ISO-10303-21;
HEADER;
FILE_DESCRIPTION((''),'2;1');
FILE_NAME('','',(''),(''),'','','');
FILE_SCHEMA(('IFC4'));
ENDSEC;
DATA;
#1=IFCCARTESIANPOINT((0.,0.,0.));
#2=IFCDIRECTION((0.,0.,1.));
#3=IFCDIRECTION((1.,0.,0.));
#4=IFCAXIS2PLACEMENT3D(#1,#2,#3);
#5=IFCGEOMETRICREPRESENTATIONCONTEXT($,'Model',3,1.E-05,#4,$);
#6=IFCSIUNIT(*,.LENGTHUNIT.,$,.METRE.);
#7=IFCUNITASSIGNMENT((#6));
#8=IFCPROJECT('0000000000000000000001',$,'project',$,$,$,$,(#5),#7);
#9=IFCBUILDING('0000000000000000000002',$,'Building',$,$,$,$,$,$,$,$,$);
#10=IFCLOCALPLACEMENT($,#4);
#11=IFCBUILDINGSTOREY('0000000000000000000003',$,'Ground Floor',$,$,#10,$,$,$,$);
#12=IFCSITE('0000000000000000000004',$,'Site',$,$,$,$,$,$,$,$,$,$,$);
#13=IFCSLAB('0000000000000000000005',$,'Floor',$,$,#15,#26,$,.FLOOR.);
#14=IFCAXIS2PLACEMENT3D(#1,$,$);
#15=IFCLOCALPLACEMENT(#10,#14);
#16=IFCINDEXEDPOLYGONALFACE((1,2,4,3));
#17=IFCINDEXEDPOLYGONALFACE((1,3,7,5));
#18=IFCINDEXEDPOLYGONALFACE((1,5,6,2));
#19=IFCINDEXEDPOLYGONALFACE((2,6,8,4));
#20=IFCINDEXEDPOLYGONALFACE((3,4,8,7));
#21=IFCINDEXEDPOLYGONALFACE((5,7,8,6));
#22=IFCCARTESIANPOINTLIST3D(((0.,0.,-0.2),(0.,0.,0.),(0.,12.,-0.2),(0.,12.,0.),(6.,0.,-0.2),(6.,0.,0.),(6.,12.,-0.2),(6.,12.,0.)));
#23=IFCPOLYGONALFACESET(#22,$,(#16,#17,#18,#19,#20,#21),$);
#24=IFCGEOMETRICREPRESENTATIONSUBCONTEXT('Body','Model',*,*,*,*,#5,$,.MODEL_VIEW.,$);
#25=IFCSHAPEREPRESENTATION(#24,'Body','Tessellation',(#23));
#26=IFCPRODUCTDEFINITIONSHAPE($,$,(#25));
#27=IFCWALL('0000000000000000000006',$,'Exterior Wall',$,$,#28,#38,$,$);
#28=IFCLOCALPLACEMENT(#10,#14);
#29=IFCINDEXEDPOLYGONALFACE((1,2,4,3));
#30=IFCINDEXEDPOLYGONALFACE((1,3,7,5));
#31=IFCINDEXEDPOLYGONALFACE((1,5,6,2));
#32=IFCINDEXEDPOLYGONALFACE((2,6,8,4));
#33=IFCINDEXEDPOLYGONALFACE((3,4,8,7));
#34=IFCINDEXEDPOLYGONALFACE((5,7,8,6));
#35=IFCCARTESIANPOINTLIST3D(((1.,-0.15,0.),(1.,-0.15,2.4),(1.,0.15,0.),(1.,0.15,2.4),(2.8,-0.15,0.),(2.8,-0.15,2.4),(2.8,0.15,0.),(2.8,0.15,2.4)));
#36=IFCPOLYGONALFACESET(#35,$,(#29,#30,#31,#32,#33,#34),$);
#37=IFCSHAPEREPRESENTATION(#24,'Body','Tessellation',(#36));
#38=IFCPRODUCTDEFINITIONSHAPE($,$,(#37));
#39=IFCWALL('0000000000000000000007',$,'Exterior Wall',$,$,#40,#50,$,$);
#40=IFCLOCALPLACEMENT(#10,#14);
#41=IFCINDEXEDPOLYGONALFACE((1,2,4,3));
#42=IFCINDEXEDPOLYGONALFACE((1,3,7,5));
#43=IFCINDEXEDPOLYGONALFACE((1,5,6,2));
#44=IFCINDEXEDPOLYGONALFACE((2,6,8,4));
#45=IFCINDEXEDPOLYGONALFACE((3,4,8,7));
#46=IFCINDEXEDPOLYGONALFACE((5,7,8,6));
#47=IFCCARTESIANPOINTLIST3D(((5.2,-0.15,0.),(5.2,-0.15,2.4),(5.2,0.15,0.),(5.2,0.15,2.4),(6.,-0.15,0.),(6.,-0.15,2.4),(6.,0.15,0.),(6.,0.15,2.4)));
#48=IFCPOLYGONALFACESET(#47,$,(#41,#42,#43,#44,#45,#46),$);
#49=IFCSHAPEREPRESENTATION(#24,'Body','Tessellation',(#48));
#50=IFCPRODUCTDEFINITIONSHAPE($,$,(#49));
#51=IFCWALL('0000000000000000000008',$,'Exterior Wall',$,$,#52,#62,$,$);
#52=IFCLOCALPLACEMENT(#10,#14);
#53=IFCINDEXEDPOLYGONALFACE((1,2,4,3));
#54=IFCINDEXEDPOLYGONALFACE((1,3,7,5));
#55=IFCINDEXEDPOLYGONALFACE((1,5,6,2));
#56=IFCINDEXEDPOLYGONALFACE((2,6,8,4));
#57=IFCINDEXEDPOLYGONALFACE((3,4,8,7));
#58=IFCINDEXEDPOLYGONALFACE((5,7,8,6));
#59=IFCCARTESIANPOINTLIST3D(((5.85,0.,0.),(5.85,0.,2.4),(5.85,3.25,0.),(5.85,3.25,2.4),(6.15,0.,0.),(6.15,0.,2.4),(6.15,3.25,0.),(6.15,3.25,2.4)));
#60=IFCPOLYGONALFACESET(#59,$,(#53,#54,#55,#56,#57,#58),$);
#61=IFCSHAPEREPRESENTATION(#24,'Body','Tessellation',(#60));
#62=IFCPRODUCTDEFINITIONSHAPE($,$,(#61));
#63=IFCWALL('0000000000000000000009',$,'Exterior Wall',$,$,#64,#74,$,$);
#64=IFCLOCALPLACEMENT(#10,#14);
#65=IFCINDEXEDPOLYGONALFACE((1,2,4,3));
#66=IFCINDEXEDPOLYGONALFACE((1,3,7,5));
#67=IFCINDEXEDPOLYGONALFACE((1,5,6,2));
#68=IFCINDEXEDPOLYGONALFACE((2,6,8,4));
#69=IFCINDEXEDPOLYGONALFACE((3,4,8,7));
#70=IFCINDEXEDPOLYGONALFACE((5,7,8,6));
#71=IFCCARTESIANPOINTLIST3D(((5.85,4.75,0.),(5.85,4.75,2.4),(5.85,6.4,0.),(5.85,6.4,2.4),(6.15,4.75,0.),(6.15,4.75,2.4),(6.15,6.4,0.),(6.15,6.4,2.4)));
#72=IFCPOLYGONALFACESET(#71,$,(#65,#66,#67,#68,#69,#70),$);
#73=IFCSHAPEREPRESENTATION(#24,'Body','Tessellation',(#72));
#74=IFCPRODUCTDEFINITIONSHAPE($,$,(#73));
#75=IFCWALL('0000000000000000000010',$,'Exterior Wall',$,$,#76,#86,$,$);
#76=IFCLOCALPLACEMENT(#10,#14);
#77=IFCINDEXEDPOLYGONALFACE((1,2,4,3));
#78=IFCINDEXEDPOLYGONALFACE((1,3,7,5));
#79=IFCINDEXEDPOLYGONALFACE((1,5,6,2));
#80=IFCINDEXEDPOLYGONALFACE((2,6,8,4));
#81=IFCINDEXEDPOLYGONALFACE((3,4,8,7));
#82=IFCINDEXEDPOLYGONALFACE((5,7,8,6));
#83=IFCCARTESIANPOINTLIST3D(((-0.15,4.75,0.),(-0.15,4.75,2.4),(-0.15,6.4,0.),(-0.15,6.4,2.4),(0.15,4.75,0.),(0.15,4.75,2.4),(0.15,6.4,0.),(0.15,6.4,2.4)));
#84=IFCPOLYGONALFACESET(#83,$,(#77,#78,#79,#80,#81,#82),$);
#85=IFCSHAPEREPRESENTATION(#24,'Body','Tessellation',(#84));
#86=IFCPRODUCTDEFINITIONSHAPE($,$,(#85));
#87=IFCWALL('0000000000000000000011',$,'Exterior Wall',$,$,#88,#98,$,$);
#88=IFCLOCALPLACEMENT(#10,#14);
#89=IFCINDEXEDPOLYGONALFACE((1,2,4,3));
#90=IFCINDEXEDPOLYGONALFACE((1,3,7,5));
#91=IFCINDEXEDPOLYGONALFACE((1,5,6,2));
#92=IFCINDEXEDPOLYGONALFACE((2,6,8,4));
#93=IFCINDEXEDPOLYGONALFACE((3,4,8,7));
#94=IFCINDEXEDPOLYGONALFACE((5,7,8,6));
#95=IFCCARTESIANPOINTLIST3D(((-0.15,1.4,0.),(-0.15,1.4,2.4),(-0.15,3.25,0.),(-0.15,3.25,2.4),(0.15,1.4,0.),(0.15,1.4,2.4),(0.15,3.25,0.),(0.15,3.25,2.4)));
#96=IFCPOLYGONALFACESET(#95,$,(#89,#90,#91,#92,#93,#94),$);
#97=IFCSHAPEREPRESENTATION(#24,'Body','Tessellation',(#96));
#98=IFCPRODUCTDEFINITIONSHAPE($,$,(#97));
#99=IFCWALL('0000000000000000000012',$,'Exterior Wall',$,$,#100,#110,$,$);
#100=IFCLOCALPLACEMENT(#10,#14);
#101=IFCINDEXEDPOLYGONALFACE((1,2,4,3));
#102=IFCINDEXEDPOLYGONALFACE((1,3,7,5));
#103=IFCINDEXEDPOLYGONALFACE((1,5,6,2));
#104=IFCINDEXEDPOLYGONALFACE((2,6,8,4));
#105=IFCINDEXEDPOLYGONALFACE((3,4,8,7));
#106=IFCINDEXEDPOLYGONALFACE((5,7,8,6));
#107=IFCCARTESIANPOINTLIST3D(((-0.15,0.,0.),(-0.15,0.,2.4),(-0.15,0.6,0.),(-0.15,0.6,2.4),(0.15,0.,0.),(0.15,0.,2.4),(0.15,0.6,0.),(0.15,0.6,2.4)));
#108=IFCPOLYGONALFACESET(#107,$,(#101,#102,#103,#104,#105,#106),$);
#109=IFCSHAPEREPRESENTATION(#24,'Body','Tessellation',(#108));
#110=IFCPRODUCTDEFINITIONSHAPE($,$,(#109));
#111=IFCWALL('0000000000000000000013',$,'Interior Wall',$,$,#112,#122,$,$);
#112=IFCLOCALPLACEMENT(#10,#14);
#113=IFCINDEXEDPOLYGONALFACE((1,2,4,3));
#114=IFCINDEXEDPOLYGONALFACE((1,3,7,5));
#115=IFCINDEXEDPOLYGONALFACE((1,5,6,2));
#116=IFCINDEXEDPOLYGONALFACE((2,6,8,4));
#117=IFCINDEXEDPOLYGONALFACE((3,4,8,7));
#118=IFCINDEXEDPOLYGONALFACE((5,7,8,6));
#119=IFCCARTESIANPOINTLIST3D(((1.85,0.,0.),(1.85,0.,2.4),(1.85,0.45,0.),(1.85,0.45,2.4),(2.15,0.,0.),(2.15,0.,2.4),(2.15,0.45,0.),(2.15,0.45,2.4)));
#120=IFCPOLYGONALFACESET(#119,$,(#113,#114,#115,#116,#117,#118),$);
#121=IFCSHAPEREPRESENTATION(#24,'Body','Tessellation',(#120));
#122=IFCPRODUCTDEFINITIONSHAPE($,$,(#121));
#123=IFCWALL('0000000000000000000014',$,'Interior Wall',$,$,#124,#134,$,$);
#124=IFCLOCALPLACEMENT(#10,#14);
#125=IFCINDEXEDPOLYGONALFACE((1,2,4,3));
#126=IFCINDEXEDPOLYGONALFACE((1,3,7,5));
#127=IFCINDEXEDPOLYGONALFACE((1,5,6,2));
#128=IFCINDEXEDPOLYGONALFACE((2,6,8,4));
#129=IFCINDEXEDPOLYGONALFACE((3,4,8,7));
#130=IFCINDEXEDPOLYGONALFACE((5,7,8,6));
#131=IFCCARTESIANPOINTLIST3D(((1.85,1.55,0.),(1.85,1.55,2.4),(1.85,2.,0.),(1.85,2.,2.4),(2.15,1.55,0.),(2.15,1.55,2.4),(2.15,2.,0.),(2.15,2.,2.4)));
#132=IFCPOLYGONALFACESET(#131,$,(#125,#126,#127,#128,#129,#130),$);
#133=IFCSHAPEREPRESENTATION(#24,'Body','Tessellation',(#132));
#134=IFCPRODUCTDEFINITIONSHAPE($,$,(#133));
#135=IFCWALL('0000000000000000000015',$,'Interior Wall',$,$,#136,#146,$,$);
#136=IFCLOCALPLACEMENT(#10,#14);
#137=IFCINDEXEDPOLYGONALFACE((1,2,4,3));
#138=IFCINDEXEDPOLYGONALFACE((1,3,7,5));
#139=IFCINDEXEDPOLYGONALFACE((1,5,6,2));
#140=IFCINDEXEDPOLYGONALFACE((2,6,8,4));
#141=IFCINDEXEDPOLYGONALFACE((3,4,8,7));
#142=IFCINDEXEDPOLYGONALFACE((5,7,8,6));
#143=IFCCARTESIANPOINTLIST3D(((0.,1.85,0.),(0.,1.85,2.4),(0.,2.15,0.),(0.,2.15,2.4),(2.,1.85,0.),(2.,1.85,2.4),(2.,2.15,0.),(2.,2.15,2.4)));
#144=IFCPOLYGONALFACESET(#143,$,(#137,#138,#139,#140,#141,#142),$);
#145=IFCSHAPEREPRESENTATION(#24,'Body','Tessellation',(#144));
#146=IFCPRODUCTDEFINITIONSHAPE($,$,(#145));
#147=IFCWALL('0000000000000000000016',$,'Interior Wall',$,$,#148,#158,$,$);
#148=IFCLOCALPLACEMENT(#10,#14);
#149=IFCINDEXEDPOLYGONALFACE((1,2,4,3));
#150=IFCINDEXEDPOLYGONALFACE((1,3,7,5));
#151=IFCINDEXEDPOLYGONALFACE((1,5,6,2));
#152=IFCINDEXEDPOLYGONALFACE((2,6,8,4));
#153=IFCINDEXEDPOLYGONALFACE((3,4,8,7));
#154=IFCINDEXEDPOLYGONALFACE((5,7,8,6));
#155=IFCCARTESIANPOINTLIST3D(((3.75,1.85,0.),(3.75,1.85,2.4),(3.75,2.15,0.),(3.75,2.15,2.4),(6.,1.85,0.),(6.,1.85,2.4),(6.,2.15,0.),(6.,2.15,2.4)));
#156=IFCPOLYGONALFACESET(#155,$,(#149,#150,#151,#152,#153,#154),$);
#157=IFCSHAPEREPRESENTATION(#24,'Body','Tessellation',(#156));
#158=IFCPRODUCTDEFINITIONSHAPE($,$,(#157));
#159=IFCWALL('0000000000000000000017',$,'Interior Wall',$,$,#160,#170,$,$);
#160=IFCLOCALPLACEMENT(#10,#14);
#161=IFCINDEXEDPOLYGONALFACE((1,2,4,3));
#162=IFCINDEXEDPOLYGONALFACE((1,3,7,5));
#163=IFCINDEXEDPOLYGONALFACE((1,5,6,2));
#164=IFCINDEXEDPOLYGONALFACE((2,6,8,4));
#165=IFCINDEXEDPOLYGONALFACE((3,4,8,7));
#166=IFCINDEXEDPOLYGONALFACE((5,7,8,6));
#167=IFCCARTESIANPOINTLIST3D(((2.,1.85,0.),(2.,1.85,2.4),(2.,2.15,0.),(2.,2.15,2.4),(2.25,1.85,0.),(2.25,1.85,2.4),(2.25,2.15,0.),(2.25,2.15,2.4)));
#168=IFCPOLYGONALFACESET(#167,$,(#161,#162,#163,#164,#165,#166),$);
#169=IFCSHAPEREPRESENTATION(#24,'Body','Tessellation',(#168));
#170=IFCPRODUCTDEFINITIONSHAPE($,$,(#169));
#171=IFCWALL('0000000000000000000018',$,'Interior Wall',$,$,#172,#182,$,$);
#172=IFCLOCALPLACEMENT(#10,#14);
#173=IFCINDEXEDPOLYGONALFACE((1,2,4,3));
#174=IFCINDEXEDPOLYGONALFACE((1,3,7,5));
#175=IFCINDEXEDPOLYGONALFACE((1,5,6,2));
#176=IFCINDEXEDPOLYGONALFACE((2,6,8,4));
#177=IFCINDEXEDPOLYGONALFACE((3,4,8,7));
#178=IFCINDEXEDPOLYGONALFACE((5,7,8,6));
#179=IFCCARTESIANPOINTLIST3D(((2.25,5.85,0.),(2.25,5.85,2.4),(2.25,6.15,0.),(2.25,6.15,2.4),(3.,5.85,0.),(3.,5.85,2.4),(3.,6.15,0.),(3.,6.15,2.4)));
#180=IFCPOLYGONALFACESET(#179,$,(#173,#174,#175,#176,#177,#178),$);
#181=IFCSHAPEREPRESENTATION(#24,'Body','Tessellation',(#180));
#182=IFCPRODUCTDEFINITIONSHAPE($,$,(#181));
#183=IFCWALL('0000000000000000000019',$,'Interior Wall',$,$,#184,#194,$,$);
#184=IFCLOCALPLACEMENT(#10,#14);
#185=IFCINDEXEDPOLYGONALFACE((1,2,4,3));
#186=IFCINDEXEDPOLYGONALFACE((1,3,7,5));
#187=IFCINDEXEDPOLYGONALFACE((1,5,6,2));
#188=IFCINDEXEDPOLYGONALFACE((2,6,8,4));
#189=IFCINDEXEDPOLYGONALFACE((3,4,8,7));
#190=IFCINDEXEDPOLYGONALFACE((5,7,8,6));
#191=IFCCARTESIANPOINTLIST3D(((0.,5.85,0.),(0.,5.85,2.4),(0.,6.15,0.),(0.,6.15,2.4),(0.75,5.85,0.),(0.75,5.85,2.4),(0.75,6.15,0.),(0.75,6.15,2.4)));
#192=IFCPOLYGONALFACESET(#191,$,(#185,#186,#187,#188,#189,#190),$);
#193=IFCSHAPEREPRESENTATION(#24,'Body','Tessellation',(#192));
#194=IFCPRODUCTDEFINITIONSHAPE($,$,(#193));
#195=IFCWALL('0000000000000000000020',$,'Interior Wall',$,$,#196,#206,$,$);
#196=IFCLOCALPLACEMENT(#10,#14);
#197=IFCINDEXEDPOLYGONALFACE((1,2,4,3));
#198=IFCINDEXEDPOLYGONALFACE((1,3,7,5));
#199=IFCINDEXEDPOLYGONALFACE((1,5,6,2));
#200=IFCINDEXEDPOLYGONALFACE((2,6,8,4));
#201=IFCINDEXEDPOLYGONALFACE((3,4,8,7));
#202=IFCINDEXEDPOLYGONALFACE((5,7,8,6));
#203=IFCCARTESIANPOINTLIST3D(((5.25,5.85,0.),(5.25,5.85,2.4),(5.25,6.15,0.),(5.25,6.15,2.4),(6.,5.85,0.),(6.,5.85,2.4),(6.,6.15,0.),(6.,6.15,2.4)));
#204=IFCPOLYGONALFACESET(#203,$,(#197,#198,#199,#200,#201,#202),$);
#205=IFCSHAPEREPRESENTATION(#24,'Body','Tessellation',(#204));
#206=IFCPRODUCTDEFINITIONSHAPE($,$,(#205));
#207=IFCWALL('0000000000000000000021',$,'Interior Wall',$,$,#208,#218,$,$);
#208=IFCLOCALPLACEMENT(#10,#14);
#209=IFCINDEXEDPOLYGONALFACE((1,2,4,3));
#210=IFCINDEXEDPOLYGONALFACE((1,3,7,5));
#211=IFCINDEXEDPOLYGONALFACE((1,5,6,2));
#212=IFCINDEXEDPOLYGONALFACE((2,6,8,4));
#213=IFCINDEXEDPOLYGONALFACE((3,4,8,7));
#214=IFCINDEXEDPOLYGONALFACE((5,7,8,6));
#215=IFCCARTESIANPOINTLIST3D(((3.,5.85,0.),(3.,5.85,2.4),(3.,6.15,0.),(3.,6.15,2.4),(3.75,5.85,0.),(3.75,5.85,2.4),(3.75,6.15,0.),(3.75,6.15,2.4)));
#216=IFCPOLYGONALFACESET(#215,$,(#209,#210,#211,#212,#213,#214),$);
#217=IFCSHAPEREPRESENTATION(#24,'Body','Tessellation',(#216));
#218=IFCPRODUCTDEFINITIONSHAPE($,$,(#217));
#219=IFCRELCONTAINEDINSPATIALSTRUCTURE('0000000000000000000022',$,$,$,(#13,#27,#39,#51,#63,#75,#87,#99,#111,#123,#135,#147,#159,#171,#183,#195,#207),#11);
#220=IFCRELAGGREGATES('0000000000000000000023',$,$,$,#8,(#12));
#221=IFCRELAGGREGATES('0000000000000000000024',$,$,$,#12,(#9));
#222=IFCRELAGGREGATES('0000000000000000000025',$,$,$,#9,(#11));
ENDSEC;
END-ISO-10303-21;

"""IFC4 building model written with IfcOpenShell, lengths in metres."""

from ifc_helpers import new_model, si_unit, frame, origin_with_axes, place, context, subcontext, project, spatial, indexed_curve, outline, extrude, element, save


model = new_model("IFC4")

# Units and contexts
model_context = context("Model", 3, precision=1e-05, world=origin_with_axes())
body_context = subcontext(model_context, "Body", "Model", "MODEL_VIEW")
ifc_project = project(units=[si_unit("LENGTHUNIT", "METRE")], contexts=[model_context])

# Site, building, storey
site = spatial("IfcSite", under=ifc_project, Name="Site")
building = spatial("IfcBuilding", under=site, Name="Building")
storey_placement = place(None, origin_with_axes())
storey = spatial("IfcBuildingStorey", under=building, at=storey_placement, Name="Ground Floor")

# Slab
slab_placement = place(storey_placement, frame((0.0, 0.0, -0.2), z_axis=(0.0, 0.0, 1.0), x_axis=(1.0, 0.0, 0.0)))
element("IfcSlab", 1, at=slab_placement, inside=storey, Name="Floor", PredefinedType="FLOOR", context=body_context, shape_type="SweptSolid", body=[
    extrude(outline(indexed_curve([(0.0, 0.0), (6.0, 0.0), (6.0, 12.0), (0.0, 12.0)])), None, (0.0, 0.0, 1.0), 0.2),
])

# Walls
wall_1_placement = place(storey_placement, frame((1.0, 0.0, 0.0), z_axis=(0.0, 0.0, 1.0), x_axis=(1.0, 0.0, 0.0)))
element("IfcWall", 2, at=wall_1_placement, inside=storey, Name="Exterior Wall", context=body_context, shape_type="SweptSolid", body=[
    extrude(outline(indexed_curve([(0.0, 0.0), (0.0, 0.3), (1.8, 0.3), (1.8, 0.0), (0.0, 0.0)], self_intersect=False)), frame((0.0, -0.15, 0.0), z_axis=(0.0, 0.0, 1.0), x_axis=(1.0, 0.0, 0.0)), (0.0, 0.0, 1.0), 2.4),
])
wall_2_placement = place(storey_placement, frame((5.2, 0.0, 0.0), z_axis=(0.0, 0.0, 1.0), x_axis=(1.0, 0.0, 0.0)))
element("IfcWall", 3, at=wall_2_placement, inside=storey, Name="Exterior Wall", context=body_context, shape_type="SweptSolid", body=[
    extrude(outline(indexed_curve([(0.0, 0.0), (0.0, 0.3), (0.8, 0.3), (0.8, 0.0), (0.0, 0.0)], self_intersect=False)), frame((0.0, -0.15, 0.0), z_axis=(0.0, 0.0, 1.0), x_axis=(1.0, 0.0, 0.0)), (0.0, 0.0, 1.0), 2.4),
])
wall_3_placement = place(storey_placement, frame((6.0, 0.0, 0.0), z_axis=(0.0, 0.0, 1.0), x_axis=(0.0, 1.0, 0.0)))
element("IfcWall", 4, at=wall_3_placement, inside=storey, Name="Exterior Wall", context=body_context, shape_type="SweptSolid", body=[
    extrude(outline(indexed_curve([(0.0, 0.0), (0.0, 0.3), (3.25, 0.3), (3.25, 0.0), (0.0, 0.0)], self_intersect=False)), frame((0.0, -0.15, 0.0), z_axis=(0.0, 0.0, 1.0), x_axis=(1.0, 0.0, 0.0)), (0.0, 0.0, 1.0), 2.4),
])
for number, where, z_axis, x_axis, name in (
    (5, (6.0, 4.75, 0.0), (0.0, 0.0, 1.0), (0.0, 1.0, 0.0), "Exterior Wall"),
    (6, (0.0, 6.4, 0.0), (0.0, 0.0, 1.0), (0.0, -1.0, 0.0), "Exterior Wall"),
):
    element("IfcWall", number, at=place(storey_placement, frame(where, z_axis=z_axis, x_axis=x_axis)), inside=storey, Name=name, context=body_context, shape_type="SweptSolid", body=[
        extrude(outline(indexed_curve([(0.0, 0.0), (0.0, 0.3), (1.65, 0.3), (1.65, 0.0), (0.0, 0.0)], self_intersect=False)), frame((0.0, -0.15, 0.0), z_axis=(0.0, 0.0, 1.0), x_axis=(1.0, 0.0, 0.0)), (0.0, 0.0, 1.0), 2.4),
    ])
wall_4_placement = place(storey_placement, frame((0.0, 3.25, 0.0), z_axis=(0.0, 0.0, 1.0), x_axis=(0.0, -1.0, 0.0)))
element("IfcWall", 7, at=wall_4_placement, inside=storey, Name="Exterior Wall", context=body_context, shape_type="SweptSolid", body=[
    extrude(outline(indexed_curve([(0.0, 0.0), (0.0, 0.3), (1.85, 0.3), (1.85, 0.0), (0.0, 0.0)], self_intersect=False)), frame((0.0, -0.15, 0.0), z_axis=(0.0, 0.0, 1.0), x_axis=(1.0, 0.0, 0.0)), (0.0, 0.0, 1.0), 2.4),
])
wall_5_placement = place(storey_placement, frame((0.0, 0.6, 0.0), z_axis=(0.0, 0.0, 1.0), x_axis=(0.0, -1.0, 0.0)))
element("IfcWall", 8, at=wall_5_placement, inside=storey, Name="Exterior Wall", context=body_context, shape_type="SweptSolid", body=[
    extrude(outline(indexed_curve([(0.0, 0.0), (0.0, 0.3), (0.6, 0.3), (0.6, 0.0), (0.0, 0.0)], self_intersect=False)), frame((0.0, -0.15, 0.0), z_axis=(0.0, 0.0, 1.0), x_axis=(1.0, 0.0, 0.0)), (0.0, 0.0, 1.0), 2.4),
])
for number, where, z_axis, x_axis, name in (
    (9, (2.0, 0.0, 0.0), (0.0, 0.0, 1.0), (0.0, 1.0, 0.0), "Interior Wall"),
    (10, (2.0, 1.55, 0.0), (0.0, 0.0, 1.0), (0.0, 1.0, 0.0), "Interior Wall"),
):
    element("IfcWall", number, at=place(storey_placement, frame(where, z_axis=z_axis, x_axis=x_axis)), inside=storey, Name=name, context=body_context, shape_type="SweptSolid", body=[
        extrude(outline(indexed_curve([(0.0, 0.0), (0.0, 0.3), (0.45, 0.3), (0.45, 0.0), (0.0, 0.0)], self_intersect=False)), frame((0.0, -0.15, 0.0), z_axis=(0.0, 0.0, 1.0), x_axis=(1.0, 0.0, 0.0)), (0.0, 0.0, 1.0), 2.4),
    ])
wall_6_placement = place(storey_placement, frame((2.0, 2.0, 0.0), z_axis=(0.0, 0.0, 1.0), x_axis=(-1.0, 0.0, 0.0)))
element("IfcWall", 11, at=wall_6_placement, inside=storey, Name="Interior Wall", context=body_context, shape_type="SweptSolid", body=[
    extrude(outline(indexed_curve([(0.0, 0.0), (0.0, 0.3), (2.0, 0.3), (2.0, 0.0), (0.0, 0.0)], self_intersect=False)), frame((0.0, -0.15, 0.0), z_axis=(0.0, 0.0, 1.0), x_axis=(1.0, 0.0, 0.0)), (0.0, 0.0, 1.0), 2.4),
])
wall_7_placement = place(storey_placement, frame((6.0, 2.0, 0.0), z_axis=(0.0, 0.0, 1.0), x_axis=(-1.0, 0.0, 0.0)))
element("IfcWall", 12, at=wall_7_placement, inside=storey, Name="Interior Wall", context=body_context, shape_type="SweptSolid", body=[
    extrude(outline(indexed_curve([(0.0, 0.0), (0.0, 0.3), (2.25, 0.3), (2.25, 0.0), (0.0, 0.0)], self_intersect=False)), frame((0.0, -0.15, 0.0), z_axis=(0.0, 0.0, 1.0), x_axis=(1.0, 0.0, 0.0)), (0.0, 0.0, 1.0), 2.4),
])
wall_8_placement = place(storey_placement, frame((2.25, 2.0, 0.0), z_axis=(0.0, 0.0, 1.0), x_axis=(-1.0, 0.0, 0.0)))
element("IfcWall", 13, at=wall_8_placement, inside=storey, Name="Interior Wall", context=body_context, shape_type="SweptSolid", body=[
    extrude(outline(indexed_curve([(0.0, 0.0), (0.0, 0.3), (0.25, 0.3), (0.25, 0.0), (0.0, 0.0)], self_intersect=False)), frame((0.0, -0.15, 0.0), z_axis=(0.0, 0.0, 1.0), x_axis=(1.0, 0.0, 0.0)), (0.0, 0.0, 1.0), 2.4),
])
for number, where, z_axis, x_axis, name in (
    (14, (3.0, 6.0, 0.0), (0.0, 0.0, 1.0), (-1.0, 0.0, 0.0), "Interior Wall"),
    (15, (0.75, 6.0, 0.0), (0.0, 0.0, 1.0), (-1.0, 0.0, 0.0), "Interior Wall"),
    (16, (6.0, 6.0, 0.0), (0.0, 0.0, 1.0), (-1.0, 0.0, 0.0), "Interior Wall"),
    (17, (3.75, 6.0, 0.0), (0.0, 0.0, 1.0), (-1.0, 0.0, 0.0), "Interior Wall"),
):
    element("IfcWall", number, at=place(storey_placement, frame(where, z_axis=z_axis, x_axis=x_axis)), inside=storey, Name=name, context=body_context, shape_type="SweptSolid", body=[
        extrude(outline(indexed_curve([(0.0, 0.0), (0.0, 0.3), (0.75, 0.3), (0.75, 0.0), (0.0, 0.0)], self_intersect=False)), frame((0.0, -0.15, 0.0), z_axis=(0.0, 0.0, 1.0), x_axis=(1.0, 0.0, 0.0)), (0.0, 0.0, 1.0), 2.4),
    ])

save(model, "model.ifc")
